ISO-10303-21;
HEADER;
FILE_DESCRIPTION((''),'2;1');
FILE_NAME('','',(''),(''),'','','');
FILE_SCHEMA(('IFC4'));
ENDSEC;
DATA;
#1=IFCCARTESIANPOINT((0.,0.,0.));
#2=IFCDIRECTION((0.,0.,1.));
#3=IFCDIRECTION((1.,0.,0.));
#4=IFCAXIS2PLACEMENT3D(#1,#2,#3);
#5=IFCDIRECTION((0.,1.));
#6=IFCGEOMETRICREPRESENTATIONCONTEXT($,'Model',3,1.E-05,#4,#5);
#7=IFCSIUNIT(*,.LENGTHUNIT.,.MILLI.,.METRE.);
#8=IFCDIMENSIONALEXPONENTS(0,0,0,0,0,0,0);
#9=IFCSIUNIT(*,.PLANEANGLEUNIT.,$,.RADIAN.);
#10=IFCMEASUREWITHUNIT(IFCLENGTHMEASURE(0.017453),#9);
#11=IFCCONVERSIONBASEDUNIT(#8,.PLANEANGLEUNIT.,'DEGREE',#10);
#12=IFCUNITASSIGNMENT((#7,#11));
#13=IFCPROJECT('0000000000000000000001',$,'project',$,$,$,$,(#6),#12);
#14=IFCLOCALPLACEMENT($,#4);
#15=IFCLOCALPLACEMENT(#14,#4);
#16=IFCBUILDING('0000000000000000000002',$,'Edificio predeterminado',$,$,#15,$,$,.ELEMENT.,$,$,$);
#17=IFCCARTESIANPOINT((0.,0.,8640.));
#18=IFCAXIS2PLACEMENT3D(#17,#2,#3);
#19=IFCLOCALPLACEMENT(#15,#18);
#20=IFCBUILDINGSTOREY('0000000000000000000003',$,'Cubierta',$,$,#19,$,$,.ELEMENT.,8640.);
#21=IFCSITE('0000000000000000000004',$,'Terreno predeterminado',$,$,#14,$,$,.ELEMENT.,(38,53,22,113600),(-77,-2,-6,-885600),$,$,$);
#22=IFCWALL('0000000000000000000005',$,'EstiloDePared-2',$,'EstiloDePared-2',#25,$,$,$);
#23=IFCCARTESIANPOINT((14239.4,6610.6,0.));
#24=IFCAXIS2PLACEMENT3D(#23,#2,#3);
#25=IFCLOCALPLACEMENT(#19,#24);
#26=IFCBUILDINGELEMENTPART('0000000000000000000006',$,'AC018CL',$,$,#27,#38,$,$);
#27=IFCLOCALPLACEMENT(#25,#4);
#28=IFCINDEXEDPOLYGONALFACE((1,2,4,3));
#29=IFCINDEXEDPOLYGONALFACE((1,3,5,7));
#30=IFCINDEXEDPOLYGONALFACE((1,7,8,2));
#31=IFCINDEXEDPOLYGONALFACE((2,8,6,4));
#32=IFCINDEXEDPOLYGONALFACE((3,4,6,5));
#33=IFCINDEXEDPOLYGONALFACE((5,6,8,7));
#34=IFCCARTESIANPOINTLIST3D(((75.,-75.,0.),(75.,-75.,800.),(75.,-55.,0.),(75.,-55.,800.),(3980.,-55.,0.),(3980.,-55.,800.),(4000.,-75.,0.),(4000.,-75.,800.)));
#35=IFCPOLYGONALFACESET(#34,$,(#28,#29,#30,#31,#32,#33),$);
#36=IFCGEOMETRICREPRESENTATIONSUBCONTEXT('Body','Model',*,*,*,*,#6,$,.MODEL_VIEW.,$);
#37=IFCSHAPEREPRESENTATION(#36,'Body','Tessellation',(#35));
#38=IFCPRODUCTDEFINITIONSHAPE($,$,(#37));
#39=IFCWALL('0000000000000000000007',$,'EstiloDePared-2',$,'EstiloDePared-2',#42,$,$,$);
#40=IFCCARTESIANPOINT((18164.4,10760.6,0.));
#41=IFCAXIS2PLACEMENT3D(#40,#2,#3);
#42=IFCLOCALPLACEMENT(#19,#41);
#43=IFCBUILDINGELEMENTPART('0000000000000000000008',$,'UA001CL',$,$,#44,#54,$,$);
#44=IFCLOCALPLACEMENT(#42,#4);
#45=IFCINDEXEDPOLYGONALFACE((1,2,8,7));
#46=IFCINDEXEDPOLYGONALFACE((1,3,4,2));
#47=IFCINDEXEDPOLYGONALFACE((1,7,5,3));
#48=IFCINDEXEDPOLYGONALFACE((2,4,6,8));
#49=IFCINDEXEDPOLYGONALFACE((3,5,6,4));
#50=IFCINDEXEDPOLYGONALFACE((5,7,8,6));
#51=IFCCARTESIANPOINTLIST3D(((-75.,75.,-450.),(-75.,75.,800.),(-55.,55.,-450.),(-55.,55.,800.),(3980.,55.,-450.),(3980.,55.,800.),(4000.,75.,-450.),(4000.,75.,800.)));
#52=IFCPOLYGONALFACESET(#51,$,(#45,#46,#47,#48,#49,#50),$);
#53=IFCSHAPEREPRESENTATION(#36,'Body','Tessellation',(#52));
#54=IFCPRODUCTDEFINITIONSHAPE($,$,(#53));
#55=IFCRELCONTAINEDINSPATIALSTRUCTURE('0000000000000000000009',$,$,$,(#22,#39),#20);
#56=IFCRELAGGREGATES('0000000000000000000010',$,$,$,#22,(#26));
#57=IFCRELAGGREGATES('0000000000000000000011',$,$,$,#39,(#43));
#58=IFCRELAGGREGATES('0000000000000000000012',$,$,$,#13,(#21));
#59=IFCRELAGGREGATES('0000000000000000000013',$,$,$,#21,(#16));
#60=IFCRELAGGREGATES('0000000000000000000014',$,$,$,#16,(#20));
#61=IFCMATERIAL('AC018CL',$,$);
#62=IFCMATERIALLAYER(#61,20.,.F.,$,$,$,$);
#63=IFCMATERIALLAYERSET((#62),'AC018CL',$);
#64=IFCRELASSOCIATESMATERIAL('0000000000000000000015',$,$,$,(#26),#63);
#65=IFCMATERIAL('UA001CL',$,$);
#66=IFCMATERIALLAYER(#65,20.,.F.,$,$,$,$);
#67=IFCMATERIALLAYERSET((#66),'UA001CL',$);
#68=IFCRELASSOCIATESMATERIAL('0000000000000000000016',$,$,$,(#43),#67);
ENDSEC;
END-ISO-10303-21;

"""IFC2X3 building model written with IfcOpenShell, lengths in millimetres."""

from ifc_helpers import new_model, entity, si_unit, converted_unit, direction, frame, origin_with_axes, place, context, subcontext, project, spatial, polyline, outline, extrude, material, layer, layer_set, layer_usage, element, aggregate, save


model = new_model("IFC2X3")

# Units and contexts
model_context = context("Model", 3, precision=1e-05, world=origin_with_axes(), true_north=direction((0.0, 1.0)))
body_context = subcontext(model_context, "Body", "Model", "MODEL_VIEW")
ifc_project = project(units=[si_unit("LENGTHUNIT", "METRE", prefix="MILLI"), converted_unit("PLANEANGLEUNIT", "DEGREE", entity("IfcLengthMeasure", 0.017453), si_unit("PLANEANGLEUNIT", "RADIAN"), dimensions=[0, 0, 0, 0, 0, 0, 0])], contexts=[model_context])

# Site, building, storey
site_placement = place(None, origin_with_axes())
site = spatial("IfcSite", under=ifc_project, at=site_placement, Name="Terreno predeterminado", CompositionType="ELEMENT", RefLatitude=(38, 53, 22, 113600), RefLongitude=(-77, -2, -6, -885600))
building_placement = place(site_placement, origin_with_axes())
building = spatial("IfcBuilding", under=site, at=building_placement, Name="Edificio predeterminado", CompositionType="ELEMENT")
storey_placement = place(building_placement, frame((0.0, 0.0, 8640.0), z_axis=(0.0, 0.0, 1.0), x_axis=(1.0, 0.0, 0.0)))
storey = spatial("IfcBuildingStorey", under=building, at=storey_placement, Name="Cubierta", CompositionType="ELEMENT", Elevation=8640.0)

# Walls, building element parts
wall_1_placement = place(storey_placement, frame((14239.4, 6610.6, 0.0), z_axis=(0.0, 0.0, 1.0), x_axis=(1.0, 0.0, 0.0)))
wall_1 = element("IfcWall", 1, at=wall_1_placement, inside=storey, Name="EstiloDePared-2", ObjectType="EstiloDePared-2")
ifc_material_1 = material(Name="AC018CL")
ifc_layer_1 = layer(ifc_material_1, 20.0, ventilated=False)
ifc_layer_set_1 = layer_set([ifc_layer_1], Name="AC018CL")
ifc_layer_usage_1 = layer_usage(ifc_layer_set_1, "AXIS2", "NEGATIVE", 55.0)
building_element_part_1_placement = place(wall_1_placement, origin_with_axes())
building_element_part_1 = element("IfcBuildingElementPart", 2, at=building_element_part_1_placement, material=ifc_layer_usage_1, Name="AC018CL", context=body_context, shape_type="SweptSolid", body=[
    extrude(outline(polyline([(3980.0, -55.0), (4000.0, -75.0), (75.0, -75.0), (75.0, -55.0), (3980.0, -55.0)])), origin_with_axes(), (0.0, 0.0, 1.0), 800.0),
])
aggregate(wall_1, [building_element_part_1])
wall_2_placement = place(storey_placement, frame((18164.4, 10760.6, 0.0), z_axis=(0.0, 0.0, 1.0), x_axis=(1.0, 0.0, 0.0)))
wall_2 = element("IfcWall", 3, at=wall_2_placement, inside=storey, Name="EstiloDePared-2", ObjectType="EstiloDePared-2")
ifc_material_2 = material(Name="UA001CL")
ifc_layer_2 = layer(ifc_material_2, 20.0, ventilated=False)
ifc_layer_set_2 = layer_set([ifc_layer_2], Name="UA001CL")
ifc_layer_usage_2 = layer_usage(ifc_layer_set_2, "AXIS2", "NEGATIVE", -75.0)
building_element_part_2_placement = place(wall_2_placement, origin_with_axes())
building_element_part_2 = element("IfcBuildingElementPart", 4, at=building_element_part_2_placement, material=ifc_layer_usage_2, Name="UA001CL", context=body_context, shape_type="SweptSolid", body=[
    extrude(outline(polyline([(4000.0, 75.0), (3980.0, 55.0), (-55.0, 55.0), (-75.0, 75.0), (4000.0, 75.0)])), frame((0.0, 0.0, -450.0), z_axis=(0.0, 0.0, 1.0), x_axis=(1.0, 0.0, 0.0)), (0.0, 0.0, 1.0), 1250.0),
])
aggregate(wall_2, [building_element_part_2])

save(model, "model.ifc")
